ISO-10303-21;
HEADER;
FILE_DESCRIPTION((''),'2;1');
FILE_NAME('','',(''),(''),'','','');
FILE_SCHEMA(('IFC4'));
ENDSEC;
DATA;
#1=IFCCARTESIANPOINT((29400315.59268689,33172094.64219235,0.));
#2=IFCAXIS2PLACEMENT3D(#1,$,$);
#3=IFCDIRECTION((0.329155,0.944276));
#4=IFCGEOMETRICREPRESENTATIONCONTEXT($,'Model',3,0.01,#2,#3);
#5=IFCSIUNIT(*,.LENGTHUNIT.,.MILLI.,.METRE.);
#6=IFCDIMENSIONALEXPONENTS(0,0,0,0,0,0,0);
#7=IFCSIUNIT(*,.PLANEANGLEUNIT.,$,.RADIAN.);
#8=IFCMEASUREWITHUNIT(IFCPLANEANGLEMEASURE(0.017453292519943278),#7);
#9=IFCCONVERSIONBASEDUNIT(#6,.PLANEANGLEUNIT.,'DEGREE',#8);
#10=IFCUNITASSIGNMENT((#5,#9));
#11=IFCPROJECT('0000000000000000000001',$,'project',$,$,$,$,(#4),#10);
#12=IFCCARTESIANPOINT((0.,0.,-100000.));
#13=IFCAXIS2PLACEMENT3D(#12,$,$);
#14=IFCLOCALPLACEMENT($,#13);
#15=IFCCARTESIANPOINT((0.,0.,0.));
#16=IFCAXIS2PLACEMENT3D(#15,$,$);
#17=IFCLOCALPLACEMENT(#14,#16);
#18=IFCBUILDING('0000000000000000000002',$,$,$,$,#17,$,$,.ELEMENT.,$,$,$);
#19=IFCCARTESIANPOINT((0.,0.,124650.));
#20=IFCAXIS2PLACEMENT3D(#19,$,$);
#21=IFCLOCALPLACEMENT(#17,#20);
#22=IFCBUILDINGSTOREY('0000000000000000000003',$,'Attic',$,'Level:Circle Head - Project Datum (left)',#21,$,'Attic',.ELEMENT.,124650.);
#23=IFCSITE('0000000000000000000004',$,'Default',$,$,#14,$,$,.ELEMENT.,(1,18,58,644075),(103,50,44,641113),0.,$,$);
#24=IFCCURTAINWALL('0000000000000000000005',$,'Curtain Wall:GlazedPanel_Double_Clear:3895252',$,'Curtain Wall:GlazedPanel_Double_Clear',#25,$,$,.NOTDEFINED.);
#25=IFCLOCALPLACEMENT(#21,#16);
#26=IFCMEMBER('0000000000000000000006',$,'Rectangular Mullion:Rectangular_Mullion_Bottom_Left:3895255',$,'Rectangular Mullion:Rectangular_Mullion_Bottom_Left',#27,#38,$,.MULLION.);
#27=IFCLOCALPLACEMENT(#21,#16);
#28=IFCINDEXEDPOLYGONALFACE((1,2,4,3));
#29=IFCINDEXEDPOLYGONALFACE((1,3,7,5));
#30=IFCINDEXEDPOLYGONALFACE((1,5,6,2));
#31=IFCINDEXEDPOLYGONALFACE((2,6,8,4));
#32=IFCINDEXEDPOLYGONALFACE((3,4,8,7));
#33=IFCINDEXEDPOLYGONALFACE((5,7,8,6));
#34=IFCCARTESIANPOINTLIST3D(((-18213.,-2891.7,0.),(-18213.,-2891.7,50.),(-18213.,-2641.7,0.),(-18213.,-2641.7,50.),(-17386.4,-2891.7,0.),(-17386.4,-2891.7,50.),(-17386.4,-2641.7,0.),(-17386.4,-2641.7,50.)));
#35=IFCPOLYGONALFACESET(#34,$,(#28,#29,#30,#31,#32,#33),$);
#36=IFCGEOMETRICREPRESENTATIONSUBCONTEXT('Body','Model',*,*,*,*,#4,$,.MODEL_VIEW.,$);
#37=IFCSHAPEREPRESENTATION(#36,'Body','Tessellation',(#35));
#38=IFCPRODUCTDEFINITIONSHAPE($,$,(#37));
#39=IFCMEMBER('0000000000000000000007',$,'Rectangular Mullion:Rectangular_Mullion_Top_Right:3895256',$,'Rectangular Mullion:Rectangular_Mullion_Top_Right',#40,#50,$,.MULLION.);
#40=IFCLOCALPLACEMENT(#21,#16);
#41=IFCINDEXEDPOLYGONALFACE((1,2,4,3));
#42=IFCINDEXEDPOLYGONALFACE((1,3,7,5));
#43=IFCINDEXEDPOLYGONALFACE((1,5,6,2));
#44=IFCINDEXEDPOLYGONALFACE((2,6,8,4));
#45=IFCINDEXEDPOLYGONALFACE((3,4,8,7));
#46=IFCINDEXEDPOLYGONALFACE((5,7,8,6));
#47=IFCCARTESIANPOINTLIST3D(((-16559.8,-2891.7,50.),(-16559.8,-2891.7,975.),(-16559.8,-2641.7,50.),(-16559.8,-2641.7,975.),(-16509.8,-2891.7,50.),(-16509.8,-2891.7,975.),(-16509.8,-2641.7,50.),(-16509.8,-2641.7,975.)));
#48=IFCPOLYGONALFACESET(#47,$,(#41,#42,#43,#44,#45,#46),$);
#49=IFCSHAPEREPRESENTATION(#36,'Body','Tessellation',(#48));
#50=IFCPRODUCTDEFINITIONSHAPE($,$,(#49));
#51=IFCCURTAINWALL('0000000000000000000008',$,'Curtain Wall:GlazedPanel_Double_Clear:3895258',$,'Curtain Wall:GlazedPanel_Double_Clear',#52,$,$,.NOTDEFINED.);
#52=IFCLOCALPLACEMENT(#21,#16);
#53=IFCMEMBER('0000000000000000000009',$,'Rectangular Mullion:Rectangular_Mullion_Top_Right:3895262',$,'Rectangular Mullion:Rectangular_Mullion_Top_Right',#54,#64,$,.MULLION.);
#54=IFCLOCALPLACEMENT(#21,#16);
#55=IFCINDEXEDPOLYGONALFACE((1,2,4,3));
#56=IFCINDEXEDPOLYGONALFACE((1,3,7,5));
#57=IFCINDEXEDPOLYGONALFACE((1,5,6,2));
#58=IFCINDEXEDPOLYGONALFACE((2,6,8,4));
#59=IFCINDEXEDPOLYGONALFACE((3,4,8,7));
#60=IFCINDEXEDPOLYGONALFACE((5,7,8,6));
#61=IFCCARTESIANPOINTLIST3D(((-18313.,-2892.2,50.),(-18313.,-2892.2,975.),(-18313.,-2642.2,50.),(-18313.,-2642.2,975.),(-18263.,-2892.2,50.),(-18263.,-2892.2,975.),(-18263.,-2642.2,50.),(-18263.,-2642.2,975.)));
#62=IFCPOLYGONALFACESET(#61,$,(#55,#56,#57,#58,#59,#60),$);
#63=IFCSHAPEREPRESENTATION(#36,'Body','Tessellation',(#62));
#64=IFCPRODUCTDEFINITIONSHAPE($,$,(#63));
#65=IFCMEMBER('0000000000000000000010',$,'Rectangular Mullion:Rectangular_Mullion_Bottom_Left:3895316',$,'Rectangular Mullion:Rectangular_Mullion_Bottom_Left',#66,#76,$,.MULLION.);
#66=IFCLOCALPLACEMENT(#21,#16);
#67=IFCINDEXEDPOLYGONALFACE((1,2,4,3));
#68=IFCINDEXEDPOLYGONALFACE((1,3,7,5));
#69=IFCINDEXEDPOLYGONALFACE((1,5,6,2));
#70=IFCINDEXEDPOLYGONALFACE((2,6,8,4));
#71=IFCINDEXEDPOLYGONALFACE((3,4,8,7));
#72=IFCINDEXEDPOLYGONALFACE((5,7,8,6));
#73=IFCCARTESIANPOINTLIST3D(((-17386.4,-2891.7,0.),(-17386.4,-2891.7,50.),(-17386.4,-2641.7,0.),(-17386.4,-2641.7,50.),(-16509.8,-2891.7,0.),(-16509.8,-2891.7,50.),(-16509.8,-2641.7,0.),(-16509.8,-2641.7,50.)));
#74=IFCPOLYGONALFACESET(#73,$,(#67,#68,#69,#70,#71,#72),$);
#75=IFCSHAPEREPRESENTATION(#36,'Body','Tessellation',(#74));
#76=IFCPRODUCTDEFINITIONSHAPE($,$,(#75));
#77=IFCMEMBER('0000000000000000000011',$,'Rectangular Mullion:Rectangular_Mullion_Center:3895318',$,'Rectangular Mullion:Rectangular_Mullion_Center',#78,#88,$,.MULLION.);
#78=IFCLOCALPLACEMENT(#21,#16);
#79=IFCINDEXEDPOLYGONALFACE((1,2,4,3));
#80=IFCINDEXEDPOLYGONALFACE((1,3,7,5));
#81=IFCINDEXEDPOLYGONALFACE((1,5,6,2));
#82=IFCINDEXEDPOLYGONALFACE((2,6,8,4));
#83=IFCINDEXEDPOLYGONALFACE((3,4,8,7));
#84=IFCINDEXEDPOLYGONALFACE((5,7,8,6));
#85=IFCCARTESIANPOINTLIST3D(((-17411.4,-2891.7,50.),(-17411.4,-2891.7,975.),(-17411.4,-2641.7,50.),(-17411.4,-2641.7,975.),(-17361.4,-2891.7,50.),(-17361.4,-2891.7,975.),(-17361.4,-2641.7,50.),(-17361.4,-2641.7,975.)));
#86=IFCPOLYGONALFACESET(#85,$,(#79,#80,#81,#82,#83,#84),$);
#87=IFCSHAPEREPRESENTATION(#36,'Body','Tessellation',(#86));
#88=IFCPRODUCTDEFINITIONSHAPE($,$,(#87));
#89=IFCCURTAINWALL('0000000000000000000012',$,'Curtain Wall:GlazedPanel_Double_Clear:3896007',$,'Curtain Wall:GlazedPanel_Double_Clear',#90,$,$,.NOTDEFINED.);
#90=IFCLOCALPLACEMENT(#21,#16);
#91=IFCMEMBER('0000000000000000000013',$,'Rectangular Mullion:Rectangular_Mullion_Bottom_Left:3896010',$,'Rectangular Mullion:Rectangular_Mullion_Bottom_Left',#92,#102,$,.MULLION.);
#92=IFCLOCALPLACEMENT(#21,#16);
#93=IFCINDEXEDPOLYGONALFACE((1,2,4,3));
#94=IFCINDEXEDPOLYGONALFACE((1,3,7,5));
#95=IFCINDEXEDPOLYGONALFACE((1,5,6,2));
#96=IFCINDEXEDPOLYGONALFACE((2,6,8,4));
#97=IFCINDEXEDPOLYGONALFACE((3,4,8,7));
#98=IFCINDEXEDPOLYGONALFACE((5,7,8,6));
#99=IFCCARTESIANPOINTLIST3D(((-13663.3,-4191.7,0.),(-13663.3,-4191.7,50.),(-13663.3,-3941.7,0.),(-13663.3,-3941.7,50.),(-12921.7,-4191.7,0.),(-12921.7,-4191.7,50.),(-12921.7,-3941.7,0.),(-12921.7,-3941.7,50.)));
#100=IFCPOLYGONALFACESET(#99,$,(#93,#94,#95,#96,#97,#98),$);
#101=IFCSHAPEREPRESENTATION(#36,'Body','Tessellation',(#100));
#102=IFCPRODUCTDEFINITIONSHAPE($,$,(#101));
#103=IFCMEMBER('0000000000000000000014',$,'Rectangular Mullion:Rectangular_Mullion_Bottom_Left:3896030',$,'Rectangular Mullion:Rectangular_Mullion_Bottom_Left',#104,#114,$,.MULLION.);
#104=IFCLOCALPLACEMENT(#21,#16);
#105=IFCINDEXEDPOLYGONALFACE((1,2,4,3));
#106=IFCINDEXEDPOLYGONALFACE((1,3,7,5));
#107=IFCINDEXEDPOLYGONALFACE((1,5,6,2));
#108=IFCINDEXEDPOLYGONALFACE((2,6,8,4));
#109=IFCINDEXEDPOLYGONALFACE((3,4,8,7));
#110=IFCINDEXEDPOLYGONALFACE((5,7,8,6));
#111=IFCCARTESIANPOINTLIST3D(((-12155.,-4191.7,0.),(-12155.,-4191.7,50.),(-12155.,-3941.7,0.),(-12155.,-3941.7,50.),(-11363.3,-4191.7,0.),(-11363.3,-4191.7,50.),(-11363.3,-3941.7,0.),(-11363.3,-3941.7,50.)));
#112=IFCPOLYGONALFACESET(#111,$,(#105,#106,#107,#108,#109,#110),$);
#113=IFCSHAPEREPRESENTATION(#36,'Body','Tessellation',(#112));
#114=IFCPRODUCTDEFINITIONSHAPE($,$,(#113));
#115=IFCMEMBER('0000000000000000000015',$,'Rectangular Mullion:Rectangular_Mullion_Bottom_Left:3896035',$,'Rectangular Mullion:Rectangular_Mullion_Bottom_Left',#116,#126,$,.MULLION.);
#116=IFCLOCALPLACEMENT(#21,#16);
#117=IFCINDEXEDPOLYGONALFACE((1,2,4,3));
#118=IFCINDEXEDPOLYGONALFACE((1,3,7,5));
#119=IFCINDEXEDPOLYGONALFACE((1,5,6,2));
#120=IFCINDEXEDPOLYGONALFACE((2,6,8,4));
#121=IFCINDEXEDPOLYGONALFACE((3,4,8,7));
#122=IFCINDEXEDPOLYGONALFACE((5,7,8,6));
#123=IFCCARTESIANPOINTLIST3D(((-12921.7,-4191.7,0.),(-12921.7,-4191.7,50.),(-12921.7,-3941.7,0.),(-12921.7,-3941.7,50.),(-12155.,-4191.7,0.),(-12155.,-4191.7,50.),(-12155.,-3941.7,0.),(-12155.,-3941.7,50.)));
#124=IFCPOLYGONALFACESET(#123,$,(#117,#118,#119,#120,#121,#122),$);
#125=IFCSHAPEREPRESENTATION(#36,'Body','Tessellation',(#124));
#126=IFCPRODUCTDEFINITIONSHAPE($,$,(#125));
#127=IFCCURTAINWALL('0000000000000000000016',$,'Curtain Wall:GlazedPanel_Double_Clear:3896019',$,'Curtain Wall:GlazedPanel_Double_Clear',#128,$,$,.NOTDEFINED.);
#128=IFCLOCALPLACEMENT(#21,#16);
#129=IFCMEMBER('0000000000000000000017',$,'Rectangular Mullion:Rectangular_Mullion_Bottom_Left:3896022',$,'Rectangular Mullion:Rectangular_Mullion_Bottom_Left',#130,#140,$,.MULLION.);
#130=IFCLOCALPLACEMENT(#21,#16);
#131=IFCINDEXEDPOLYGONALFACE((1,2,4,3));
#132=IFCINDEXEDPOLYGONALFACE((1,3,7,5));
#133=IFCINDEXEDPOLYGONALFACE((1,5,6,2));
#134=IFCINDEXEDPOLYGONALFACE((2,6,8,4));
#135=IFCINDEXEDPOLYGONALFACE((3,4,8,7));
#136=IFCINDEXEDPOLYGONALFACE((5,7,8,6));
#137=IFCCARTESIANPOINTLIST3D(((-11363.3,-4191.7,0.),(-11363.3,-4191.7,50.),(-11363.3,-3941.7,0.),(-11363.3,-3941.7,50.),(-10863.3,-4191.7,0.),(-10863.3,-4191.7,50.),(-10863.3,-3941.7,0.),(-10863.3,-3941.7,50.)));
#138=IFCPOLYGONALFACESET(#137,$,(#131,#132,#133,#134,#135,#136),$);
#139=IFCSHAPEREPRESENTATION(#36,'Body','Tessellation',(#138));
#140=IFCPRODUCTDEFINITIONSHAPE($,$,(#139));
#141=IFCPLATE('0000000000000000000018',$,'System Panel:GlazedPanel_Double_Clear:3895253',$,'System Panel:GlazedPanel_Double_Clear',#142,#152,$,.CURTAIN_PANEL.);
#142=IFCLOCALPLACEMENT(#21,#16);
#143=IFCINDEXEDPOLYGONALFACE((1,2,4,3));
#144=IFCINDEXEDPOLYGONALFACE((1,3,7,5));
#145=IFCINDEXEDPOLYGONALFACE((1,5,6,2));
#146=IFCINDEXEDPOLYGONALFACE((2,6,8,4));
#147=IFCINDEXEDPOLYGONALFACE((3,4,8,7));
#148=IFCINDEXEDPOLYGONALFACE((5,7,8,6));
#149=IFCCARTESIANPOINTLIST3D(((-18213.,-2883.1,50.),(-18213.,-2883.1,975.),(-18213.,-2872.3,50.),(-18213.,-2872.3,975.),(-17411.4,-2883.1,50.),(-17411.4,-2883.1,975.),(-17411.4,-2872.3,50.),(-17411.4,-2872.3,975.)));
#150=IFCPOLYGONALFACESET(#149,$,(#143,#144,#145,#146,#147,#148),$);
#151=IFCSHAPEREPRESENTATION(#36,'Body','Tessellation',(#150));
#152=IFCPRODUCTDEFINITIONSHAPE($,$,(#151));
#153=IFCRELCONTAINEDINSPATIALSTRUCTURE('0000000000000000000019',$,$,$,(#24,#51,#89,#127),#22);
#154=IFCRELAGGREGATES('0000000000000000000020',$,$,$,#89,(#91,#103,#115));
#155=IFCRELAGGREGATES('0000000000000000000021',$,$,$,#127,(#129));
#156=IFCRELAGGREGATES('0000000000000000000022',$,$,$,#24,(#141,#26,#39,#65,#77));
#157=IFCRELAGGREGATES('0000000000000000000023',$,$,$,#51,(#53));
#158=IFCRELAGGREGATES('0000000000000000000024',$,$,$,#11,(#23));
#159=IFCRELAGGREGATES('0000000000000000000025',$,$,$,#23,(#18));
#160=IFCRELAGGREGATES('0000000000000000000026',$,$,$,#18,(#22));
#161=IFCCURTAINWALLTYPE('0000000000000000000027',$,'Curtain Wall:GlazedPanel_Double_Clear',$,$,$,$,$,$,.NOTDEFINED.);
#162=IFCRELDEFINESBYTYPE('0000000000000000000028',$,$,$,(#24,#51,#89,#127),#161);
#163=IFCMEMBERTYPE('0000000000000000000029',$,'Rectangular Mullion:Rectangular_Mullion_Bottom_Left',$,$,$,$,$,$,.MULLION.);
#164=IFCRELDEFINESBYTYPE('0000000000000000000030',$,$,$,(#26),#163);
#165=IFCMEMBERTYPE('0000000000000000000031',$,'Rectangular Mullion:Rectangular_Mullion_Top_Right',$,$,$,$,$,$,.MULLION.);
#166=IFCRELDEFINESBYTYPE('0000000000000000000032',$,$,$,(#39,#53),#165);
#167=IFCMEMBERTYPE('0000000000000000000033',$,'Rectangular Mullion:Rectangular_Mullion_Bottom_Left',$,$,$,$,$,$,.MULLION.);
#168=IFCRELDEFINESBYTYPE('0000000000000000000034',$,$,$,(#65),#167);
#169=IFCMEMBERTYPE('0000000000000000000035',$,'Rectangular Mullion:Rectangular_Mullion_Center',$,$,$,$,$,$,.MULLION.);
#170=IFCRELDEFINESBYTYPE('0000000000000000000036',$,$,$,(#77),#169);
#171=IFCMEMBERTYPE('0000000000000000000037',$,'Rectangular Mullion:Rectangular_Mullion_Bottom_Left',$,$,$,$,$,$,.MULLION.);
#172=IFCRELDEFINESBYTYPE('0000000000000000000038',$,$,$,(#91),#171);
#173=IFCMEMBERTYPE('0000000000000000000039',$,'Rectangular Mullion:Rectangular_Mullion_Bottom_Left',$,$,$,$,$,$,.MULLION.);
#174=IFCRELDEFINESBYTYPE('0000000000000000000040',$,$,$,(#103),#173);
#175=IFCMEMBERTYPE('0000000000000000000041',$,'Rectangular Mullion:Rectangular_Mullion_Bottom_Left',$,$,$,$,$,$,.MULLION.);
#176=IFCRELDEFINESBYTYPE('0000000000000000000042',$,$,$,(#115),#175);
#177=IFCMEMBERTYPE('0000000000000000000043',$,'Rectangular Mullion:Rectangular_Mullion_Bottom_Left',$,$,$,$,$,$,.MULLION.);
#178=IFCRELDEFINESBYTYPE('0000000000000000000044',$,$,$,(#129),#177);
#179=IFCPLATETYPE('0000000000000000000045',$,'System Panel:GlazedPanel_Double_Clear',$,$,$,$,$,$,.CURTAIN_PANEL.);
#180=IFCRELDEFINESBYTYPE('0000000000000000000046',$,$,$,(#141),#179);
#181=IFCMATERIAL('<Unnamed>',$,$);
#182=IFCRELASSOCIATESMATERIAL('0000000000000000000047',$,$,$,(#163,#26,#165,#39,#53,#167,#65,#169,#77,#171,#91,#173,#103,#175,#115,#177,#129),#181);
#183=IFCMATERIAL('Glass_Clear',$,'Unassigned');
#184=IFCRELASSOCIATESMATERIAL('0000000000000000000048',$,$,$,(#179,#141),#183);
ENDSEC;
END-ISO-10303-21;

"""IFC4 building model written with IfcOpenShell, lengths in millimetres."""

from ifc_helpers import new_model, entity, si_unit, converted_unit, direction, frame, origin, place, context, subcontext, project, spatial, indexed_curve, outline, extrude, source, transform, mapped, material, type_object, type_shapes, element, aggregate, save


model = new_model("IFC4")

# Units and contexts
model_context = context("Model", 3, precision=0.01, world=frame((29400315.59268689, 33172094.64219235, 0.0)), true_north=direction((0.329155, 0.944276)))
body_context = subcontext(model_context, "Body", "Model", "MODEL_VIEW")
ifc_project = project(units=[si_unit("LENGTHUNIT", "METRE", prefix="MILLI"), converted_unit("PLANEANGLEUNIT", "DEGREE", entity("IfcPlaneAngleMeasure", 0.017453292519943278), si_unit("PLANEANGLEUNIT", "RADIAN"), dimensions=[0, 0, 0, 0, 0, 0, 0])], contexts=[model_context])

# Site, building, storey
site_placement = place(None, frame((0.0, 0.0, -100000.0)))
site = spatial("IfcSite", under=ifc_project, at=site_placement, Name="Default", CompositionType="ELEMENT", RefLatitude=(1, 18, 58, 644075), RefLongitude=(103, 50, 44, 641113), RefElevation=0.0)
building_placement = place(site_placement, origin())
building = spatial("IfcBuilding", under=site, at=building_placement, CompositionType="ELEMENT")
storey_placement = place(building_placement, frame((0.0, 0.0, 124650.0)))
storey = spatial("IfcBuildingStorey", under=building, at=storey_placement, Name="Attic", ObjectType="Level:Circle Head - Project Datum (left)", LongName="Attic", CompositionType="ELEMENT", Elevation=124650.0)

# Curtain wall, members
curtain_wall_type = type_object("IfcCurtainWallType", Name="Curtain Wall:GlazedPanel_Double_Clear", PredefinedType="NOTDEFINED")
curtain_wall_1_placement = place(storey_placement, frame((0.0, 0.0, -124650.0)))
curtain_wall_1 = element("IfcCurtainWall", 1, at=curtain_wall_1_placement, inside=storey, type_object=curtain_wall_type, Name="Curtain Wall:GlazedPanel_Double_Clear:3895252", ObjectType="Curtain Wall:GlazedPanel_Double_Clear", PredefinedType="NOTDEFINED")
ifc_material_1 = material(Name="<Unnamed>")
member_type_1 = type_object("IfcMemberType", Name="Rectangular Mullion:Rectangular_Mullion_Bottom_Left", PredefinedType="MULLION", material=ifc_material_1)
shared_shape_1 = source(origin(), body_context, "Body", "SweptSolid", [
    extrude(outline(indexed_curve([(-25.0, -125.0), (25.0, -125.0), (25.0, 125.0), (-25.0, 125.0), (-25.0, -125.0)], self_intersect=False)), frame((-25.0, 0.0, -826.6), z_axis=(0.0, 0.0, 1.0), x_axis=(-1.0, 0.0, 0.0)), (0.0, 0.0, 1.0), 826.6),
])
type_shapes(member_type_1, [shared_shape_1])
member_1_placement = place(curtain_wall_1_placement, frame((-18213.0, -2766.7, 124650.0), z_axis=(-1.0, 0.0, 0.0), x_axis=(0.0, 0.0, -1.0)))
member_1 = element("IfcMember", 2, at=member_1_placement, type_object=member_type_1, material=ifc_material_1, Name="Rectangular Mullion:Rectangular_Mullion_Bottom_Left:3895255", ObjectType="Rectangular Mullion:Rectangular_Mullion_Bottom_Left", PredefinedType="MULLION", context=body_context, shape_type="MappedRepresentation", body=[
    mapped(shared_shape_1, transform((0.0, 0.0, 0.0), scale=1.0)),
])
member_type_2 = type_object("IfcMemberType", Name="Rectangular Mullion:Rectangular_Mullion_Top_Right", PredefinedType="MULLION", material=ifc_material_1)
shared_shape_2 = source(origin(), body_context, "Body", "SweptSolid", [
    extrude(outline(indexed_curve([(-25.0, -125.0), (25.0, -125.0), (25.0, 125.0), (-25.0, 125.0), (-25.0, -125.0)], self_intersect=False)), frame((-25.0, 0.0, -925.0), z_axis=(0.0, 0.0, 1.0), x_axis=(-1.0, 0.0, 0.0)), (0.0, 0.0, 1.0), 925.0),
])
type_shapes(member_type_2, [shared_shape_2])
member_2_placement = place(curtain_wall_1_placement, frame((-16509.8, -2766.7, 124700.0), z_axis=(0.0, 0.0, -1.0), x_axis=(1.0, 0.0, 0.0)))
member_2 = element("IfcMember", 3, at=member_2_placement, type_object=member_type_2, material=ifc_material_1, Name="Rectangular Mullion:Rectangular_Mullion_Top_Right:3895256", ObjectType="Rectangular Mullion:Rectangular_Mullion_Top_Right", PredefinedType="MULLION", context=body_context, shape_type="MappedRepresentation", body=[
    mapped(shared_shape_2, transform((0.0, 0.0, 0.0), scale=1.0)),
])

# Curtain wall, member
curtain_wall_2_placement = place(storey_placement, frame((0.0, 0.0, -124650.0)))
curtain_wall_2 = element("IfcCurtainWall", 4, at=curtain_wall_2_placement, inside=storey, type_object=curtain_wall_type, Name="Curtain Wall:GlazedPanel_Double_Clear:3895258", ObjectType="Curtain Wall:GlazedPanel_Double_Clear", PredefinedType="NOTDEFINED")
member_3_placement = place(curtain_wall_2_placement, frame((-18263.0, -2767.2, 124700.0), z_axis=(0.0, 0.0, -1.0), x_axis=(1.0, 0.0, 0.0)))
member_3 = element("IfcMember", 5, at=member_3_placement, type_object=member_type_2, material=ifc_material_1, Name="Rectangular Mullion:Rectangular_Mullion_Top_Right:3895262", ObjectType="Rectangular Mullion:Rectangular_Mullion_Top_Right", PredefinedType="MULLION", context=body_context, shape_type="MappedRepresentation", body=[
    mapped(shared_shape_2, transform((0.0, 0.0, 0.0), scale=1.0)),
])

# Members
member_type_3 = type_object("IfcMemberType", Name="Rectangular Mullion:Rectangular_Mullion_Bottom_Left", PredefinedType="MULLION", material=ifc_material_1)
shared_shape_3 = source(origin(), body_context, "Body", "SweptSolid", [
    extrude(outline(indexed_curve([(-25.0, -125.0), (25.0, -125.0), (25.0, 125.0), (-25.0, 125.0), (-25.0, -125.0)], self_intersect=False)), frame((-25.0, 0.0, -876.6), z_axis=(0.0, 0.0, 1.0), x_axis=(-1.0, 0.0, 0.0)), (0.0, 0.0, 1.0), 876.6),
])
type_shapes(member_type_3, [shared_shape_3])
member_4_placement = place(curtain_wall_1_placement, frame((-17386.4, -2766.7, 124650.0), z_axis=(-1.0, 0.0, 0.0), x_axis=(0.0, 0.0, -1.0)))
member_4 = element("IfcMember", 6, at=member_4_placement, type_object=member_type_3, material=ifc_material_1, Name="Rectangular Mullion:Rectangular_Mullion_Bottom_Left:3895316", ObjectType="Rectangular Mullion:Rectangular_Mullion_Bottom_Left", PredefinedType="MULLION", context=body_context, shape_type="MappedRepresentation", body=[
    mapped(shared_shape_3, transform((0.0, 0.0, 0.0), scale=1.0)),
])
member_type_4 = type_object("IfcMemberType", Name="Rectangular Mullion:Rectangular_Mullion_Center", PredefinedType="MULLION", material=ifc_material_1)
shared_shape_4 = source(origin(), body_context, "Body", "SweptSolid", [
    extrude(outline(indexed_curve([(-25.0, -125.0), (25.0, -125.0), (25.0, 125.0), (-25.0, 125.0), (-25.0, -125.0)], self_intersect=False)), frame((0.0, 0.0, -925.0), z_axis=(0.0, 0.0, 1.0), x_axis=(-1.0, 0.0, 0.0)), (0.0, 0.0, 1.0), 925.0),
])
type_shapes(member_type_4, [shared_shape_4])
member_5_placement = place(curtain_wall_1_placement, frame((-17386.4, -2766.7, 124700.0), z_axis=(0.0, 0.0, -1.0), x_axis=(1.0, 0.0, 0.0)))
member_5 = element("IfcMember", 7, at=member_5_placement, type_object=member_type_4, material=ifc_material_1, Name="Rectangular Mullion:Rectangular_Mullion_Center:3895318", ObjectType="Rectangular Mullion:Rectangular_Mullion_Center", PredefinedType="MULLION", context=body_context, shape_type="MappedRepresentation", body=[
    mapped(shared_shape_4, transform((0.0, 0.0, 0.0), scale=1.0)),
])

# Curtain wall, members
curtain_wall_3_placement = place(storey_placement, frame((0.0, 0.0, -124650.0)))
curtain_wall_3 = element("IfcCurtainWall", 8, at=curtain_wall_3_placement, inside=storey, type_object=curtain_wall_type, Name="Curtain Wall:GlazedPanel_Double_Clear:3896007", ObjectType="Curtain Wall:GlazedPanel_Double_Clear", PredefinedType="NOTDEFINED")
member_type_5 = type_object("IfcMemberType", Name="Rectangular Mullion:Rectangular_Mullion_Bottom_Left", PredefinedType="MULLION", material=ifc_material_1)
shared_shape_5 = source(origin(), body_context, "Body", "SweptSolid", [
    extrude(outline(indexed_curve([(-25.0, -125.0), (25.0, -125.0), (25.0, 125.0), (-25.0, 125.0), (-25.0, -125.0)], self_intersect=False)), frame((-25.0, 0.0, -741.7), z_axis=(0.0, 0.0, 1.0), x_axis=(-1.0, 0.0, 0.0)), (0.0, 0.0, 1.0), 741.7),
])
type_shapes(member_type_5, [shared_shape_5])
member_6_placement = place(curtain_wall_3_placement, frame((-13663.3, -4066.7, 124650.0), z_axis=(-1.0, 0.0, 0.0), x_axis=(0.0, 0.0, -1.0)))
member_6 = element("IfcMember", 9, at=member_6_placement, type_object=member_type_5, material=ifc_material_1, Name="Rectangular Mullion:Rectangular_Mullion_Bottom_Left:3896010", ObjectType="Rectangular Mullion:Rectangular_Mullion_Bottom_Left", PredefinedType="MULLION", context=body_context, shape_type="MappedRepresentation", body=[
    mapped(shared_shape_5, transform((0.0, 0.0, 0.0), scale=1.0)),
])
member_type_6 = type_object("IfcMemberType", Name="Rectangular Mullion:Rectangular_Mullion_Bottom_Left", PredefinedType="MULLION", material=ifc_material_1)
shared_shape_6 = source(origin(), body_context, "Body", "SweptSolid", [
    extrude(outline(indexed_curve([(-25.0, -125.0), (25.0, -125.0), (25.0, 125.0), (-25.0, 125.0), (-25.0, -125.0)], self_intersect=False)), frame((-25.0, 0.0, -791.7), z_axis=(0.0, 0.0, 1.0), x_axis=(-1.0, 0.0, 0.0)), (0.0, 0.0, 1.0), 791.7),
])
type_shapes(member_type_6, [shared_shape_6])
member_7_placement = place(curtain_wall_3_placement, frame((-12155.0, -4066.7, 124650.0), z_axis=(-1.0, 0.0, 0.0), x_axis=(0.0, 0.0, -1.0)))
member_7 = element("IfcMember", 10, at=member_7_placement, type_object=member_type_6, material=ifc_material_1, Name="Rectangular Mullion:Rectangular_Mullion_Bottom_Left:3896030", ObjectType="Rectangular Mullion:Rectangular_Mullion_Bottom_Left", PredefinedType="MULLION", context=body_context, shape_type="MappedRepresentation", body=[
    mapped(shared_shape_6, transform((0.0, 0.0, 0.0), scale=1.0)),
])
member_type_7 = type_object("IfcMemberType", Name="Rectangular Mullion:Rectangular_Mullion_Bottom_Left", PredefinedType="MULLION", material=ifc_material_1)
shared_shape_7 = source(origin(), body_context, "Body", "SweptSolid", [
    extrude(outline(indexed_curve([(-25.0, -125.0), (25.0, -125.0), (25.0, 125.0), (-25.0, 125.0), (-25.0, -125.0)], self_intersect=False)), frame((-25.0, 0.0, -766.7), z_axis=(0.0, 0.0, 1.0), x_axis=(-1.0, 0.0, 0.0)), (0.0, 0.0, 1.0), 766.7),
])
type_shapes(member_type_7, [shared_shape_7])
member_8_placement = place(curtain_wall_3_placement, frame((-12921.7, -4066.7, 124650.0), z_axis=(-1.0, 0.0, 0.0), x_axis=(0.0, 0.0, -1.0)))
member_8 = element("IfcMember", 11, at=member_8_placement, type_object=member_type_7, material=ifc_material_1, Name="Rectangular Mullion:Rectangular_Mullion_Bottom_Left:3896035", ObjectType="Rectangular Mullion:Rectangular_Mullion_Bottom_Left", PredefinedType="MULLION", context=body_context, shape_type="MappedRepresentation", body=[
    mapped(shared_shape_7, transform((0.0, 0.0, 0.0), scale=1.0)),
])
aggregate(curtain_wall_3, [member_6, member_7, member_8])

# Curtain wall, member
curtain_wall_4_placement = place(storey_placement, frame((0.0, 0.0, -124650.0)))
curtain_wall_4 = element("IfcCurtainWall", 12, at=curtain_wall_4_placement, inside=storey, type_object=curtain_wall_type, Name="Curtain Wall:GlazedPanel_Double_Clear:3896019", ObjectType="Curtain Wall:GlazedPanel_Double_Clear", PredefinedType="NOTDEFINED")
member_type_8 = type_object("IfcMemberType", Name="Rectangular Mullion:Rectangular_Mullion_Bottom_Left", PredefinedType="MULLION", material=ifc_material_1)
shared_shape_8 = source(origin(), body_context, "Body", "SweptSolid", [
    extrude(outline(indexed_curve([(-25.0, -125.0), (25.0, -125.0), (25.0, 125.0), (-25.0, 125.0), (-25.0, -125.0)], self_intersect=False)), frame((-25.0, 0.0, -500.0), z_axis=(0.0, 0.0, 1.0), x_axis=(-1.0, 0.0, 0.0)), (0.0, 0.0, 1.0), 500.0),
])
type_shapes(member_type_8, [shared_shape_8])
member_9_placement = place(curtain_wall_4_placement, frame((-11363.3, -4066.7, 124650.0), z_axis=(-1.0, 0.0, 0.0), x_axis=(0.0, 0.0, -1.0)))
member_9 = element("IfcMember", 13, at=member_9_placement, type_object=member_type_8, material=ifc_material_1, Name="Rectangular Mullion:Rectangular_Mullion_Bottom_Left:3896022", ObjectType="Rectangular Mullion:Rectangular_Mullion_Bottom_Left", PredefinedType="MULLION", context=body_context, shape_type="MappedRepresentation", body=[
    mapped(shared_shape_8, transform((0.0, 0.0, 0.0), scale=1.0)),
])
aggregate(curtain_wall_4, [member_9])

# Plate
ifc_material_2 = material(Name="Glass_Clear", Category="Unassigned")
plate_type_1 = type_object("IfcPlateType", Name="System Panel:GlazedPanel_Double_Clear", PredefinedType="CURTAIN_PANEL", material=ifc_material_2)
shared_shape_9 = source(origin(), body_context, "Body", "SweptSolid", [
    extrude(outline(indexed_curve([(-5.4, -400.8), (5.4, -400.8), (5.4, 400.8), (-5.4, 400.8), (-5.4, -400.8)], self_intersect=False)), frame((0.0, -111.0, 0.0), z_axis=(0.0, 0.0, 1.0), x_axis=(0.0, 1.0, 0.0)), (0.0, 0.0, 1.0), 925.0),
])
type_shapes(plate_type_1, [shared_shape_9])
plate_1_placement = place(curtain_wall_1_placement, frame((-17812.2, -2766.7, 124700.0)))
plate_1 = element("IfcPlate", 14, at=plate_1_placement, type_object=plate_type_1, material=ifc_material_2, Name="System Panel:GlazedPanel_Double_Clear:3895253", ObjectType="System Panel:GlazedPanel_Double_Clear", PredefinedType="CURTAIN_PANEL", context=body_context, shape_type="MappedRepresentation", body=[
    mapped(shared_shape_9, transform((0.0, 0.0, 0.0), scale=1.0)),
])
aggregate(curtain_wall_1, [plate_1, member_1, member_2, member_4, member_5])
aggregate(curtain_wall_2, [member_3])

save(model, "model.ifc")
